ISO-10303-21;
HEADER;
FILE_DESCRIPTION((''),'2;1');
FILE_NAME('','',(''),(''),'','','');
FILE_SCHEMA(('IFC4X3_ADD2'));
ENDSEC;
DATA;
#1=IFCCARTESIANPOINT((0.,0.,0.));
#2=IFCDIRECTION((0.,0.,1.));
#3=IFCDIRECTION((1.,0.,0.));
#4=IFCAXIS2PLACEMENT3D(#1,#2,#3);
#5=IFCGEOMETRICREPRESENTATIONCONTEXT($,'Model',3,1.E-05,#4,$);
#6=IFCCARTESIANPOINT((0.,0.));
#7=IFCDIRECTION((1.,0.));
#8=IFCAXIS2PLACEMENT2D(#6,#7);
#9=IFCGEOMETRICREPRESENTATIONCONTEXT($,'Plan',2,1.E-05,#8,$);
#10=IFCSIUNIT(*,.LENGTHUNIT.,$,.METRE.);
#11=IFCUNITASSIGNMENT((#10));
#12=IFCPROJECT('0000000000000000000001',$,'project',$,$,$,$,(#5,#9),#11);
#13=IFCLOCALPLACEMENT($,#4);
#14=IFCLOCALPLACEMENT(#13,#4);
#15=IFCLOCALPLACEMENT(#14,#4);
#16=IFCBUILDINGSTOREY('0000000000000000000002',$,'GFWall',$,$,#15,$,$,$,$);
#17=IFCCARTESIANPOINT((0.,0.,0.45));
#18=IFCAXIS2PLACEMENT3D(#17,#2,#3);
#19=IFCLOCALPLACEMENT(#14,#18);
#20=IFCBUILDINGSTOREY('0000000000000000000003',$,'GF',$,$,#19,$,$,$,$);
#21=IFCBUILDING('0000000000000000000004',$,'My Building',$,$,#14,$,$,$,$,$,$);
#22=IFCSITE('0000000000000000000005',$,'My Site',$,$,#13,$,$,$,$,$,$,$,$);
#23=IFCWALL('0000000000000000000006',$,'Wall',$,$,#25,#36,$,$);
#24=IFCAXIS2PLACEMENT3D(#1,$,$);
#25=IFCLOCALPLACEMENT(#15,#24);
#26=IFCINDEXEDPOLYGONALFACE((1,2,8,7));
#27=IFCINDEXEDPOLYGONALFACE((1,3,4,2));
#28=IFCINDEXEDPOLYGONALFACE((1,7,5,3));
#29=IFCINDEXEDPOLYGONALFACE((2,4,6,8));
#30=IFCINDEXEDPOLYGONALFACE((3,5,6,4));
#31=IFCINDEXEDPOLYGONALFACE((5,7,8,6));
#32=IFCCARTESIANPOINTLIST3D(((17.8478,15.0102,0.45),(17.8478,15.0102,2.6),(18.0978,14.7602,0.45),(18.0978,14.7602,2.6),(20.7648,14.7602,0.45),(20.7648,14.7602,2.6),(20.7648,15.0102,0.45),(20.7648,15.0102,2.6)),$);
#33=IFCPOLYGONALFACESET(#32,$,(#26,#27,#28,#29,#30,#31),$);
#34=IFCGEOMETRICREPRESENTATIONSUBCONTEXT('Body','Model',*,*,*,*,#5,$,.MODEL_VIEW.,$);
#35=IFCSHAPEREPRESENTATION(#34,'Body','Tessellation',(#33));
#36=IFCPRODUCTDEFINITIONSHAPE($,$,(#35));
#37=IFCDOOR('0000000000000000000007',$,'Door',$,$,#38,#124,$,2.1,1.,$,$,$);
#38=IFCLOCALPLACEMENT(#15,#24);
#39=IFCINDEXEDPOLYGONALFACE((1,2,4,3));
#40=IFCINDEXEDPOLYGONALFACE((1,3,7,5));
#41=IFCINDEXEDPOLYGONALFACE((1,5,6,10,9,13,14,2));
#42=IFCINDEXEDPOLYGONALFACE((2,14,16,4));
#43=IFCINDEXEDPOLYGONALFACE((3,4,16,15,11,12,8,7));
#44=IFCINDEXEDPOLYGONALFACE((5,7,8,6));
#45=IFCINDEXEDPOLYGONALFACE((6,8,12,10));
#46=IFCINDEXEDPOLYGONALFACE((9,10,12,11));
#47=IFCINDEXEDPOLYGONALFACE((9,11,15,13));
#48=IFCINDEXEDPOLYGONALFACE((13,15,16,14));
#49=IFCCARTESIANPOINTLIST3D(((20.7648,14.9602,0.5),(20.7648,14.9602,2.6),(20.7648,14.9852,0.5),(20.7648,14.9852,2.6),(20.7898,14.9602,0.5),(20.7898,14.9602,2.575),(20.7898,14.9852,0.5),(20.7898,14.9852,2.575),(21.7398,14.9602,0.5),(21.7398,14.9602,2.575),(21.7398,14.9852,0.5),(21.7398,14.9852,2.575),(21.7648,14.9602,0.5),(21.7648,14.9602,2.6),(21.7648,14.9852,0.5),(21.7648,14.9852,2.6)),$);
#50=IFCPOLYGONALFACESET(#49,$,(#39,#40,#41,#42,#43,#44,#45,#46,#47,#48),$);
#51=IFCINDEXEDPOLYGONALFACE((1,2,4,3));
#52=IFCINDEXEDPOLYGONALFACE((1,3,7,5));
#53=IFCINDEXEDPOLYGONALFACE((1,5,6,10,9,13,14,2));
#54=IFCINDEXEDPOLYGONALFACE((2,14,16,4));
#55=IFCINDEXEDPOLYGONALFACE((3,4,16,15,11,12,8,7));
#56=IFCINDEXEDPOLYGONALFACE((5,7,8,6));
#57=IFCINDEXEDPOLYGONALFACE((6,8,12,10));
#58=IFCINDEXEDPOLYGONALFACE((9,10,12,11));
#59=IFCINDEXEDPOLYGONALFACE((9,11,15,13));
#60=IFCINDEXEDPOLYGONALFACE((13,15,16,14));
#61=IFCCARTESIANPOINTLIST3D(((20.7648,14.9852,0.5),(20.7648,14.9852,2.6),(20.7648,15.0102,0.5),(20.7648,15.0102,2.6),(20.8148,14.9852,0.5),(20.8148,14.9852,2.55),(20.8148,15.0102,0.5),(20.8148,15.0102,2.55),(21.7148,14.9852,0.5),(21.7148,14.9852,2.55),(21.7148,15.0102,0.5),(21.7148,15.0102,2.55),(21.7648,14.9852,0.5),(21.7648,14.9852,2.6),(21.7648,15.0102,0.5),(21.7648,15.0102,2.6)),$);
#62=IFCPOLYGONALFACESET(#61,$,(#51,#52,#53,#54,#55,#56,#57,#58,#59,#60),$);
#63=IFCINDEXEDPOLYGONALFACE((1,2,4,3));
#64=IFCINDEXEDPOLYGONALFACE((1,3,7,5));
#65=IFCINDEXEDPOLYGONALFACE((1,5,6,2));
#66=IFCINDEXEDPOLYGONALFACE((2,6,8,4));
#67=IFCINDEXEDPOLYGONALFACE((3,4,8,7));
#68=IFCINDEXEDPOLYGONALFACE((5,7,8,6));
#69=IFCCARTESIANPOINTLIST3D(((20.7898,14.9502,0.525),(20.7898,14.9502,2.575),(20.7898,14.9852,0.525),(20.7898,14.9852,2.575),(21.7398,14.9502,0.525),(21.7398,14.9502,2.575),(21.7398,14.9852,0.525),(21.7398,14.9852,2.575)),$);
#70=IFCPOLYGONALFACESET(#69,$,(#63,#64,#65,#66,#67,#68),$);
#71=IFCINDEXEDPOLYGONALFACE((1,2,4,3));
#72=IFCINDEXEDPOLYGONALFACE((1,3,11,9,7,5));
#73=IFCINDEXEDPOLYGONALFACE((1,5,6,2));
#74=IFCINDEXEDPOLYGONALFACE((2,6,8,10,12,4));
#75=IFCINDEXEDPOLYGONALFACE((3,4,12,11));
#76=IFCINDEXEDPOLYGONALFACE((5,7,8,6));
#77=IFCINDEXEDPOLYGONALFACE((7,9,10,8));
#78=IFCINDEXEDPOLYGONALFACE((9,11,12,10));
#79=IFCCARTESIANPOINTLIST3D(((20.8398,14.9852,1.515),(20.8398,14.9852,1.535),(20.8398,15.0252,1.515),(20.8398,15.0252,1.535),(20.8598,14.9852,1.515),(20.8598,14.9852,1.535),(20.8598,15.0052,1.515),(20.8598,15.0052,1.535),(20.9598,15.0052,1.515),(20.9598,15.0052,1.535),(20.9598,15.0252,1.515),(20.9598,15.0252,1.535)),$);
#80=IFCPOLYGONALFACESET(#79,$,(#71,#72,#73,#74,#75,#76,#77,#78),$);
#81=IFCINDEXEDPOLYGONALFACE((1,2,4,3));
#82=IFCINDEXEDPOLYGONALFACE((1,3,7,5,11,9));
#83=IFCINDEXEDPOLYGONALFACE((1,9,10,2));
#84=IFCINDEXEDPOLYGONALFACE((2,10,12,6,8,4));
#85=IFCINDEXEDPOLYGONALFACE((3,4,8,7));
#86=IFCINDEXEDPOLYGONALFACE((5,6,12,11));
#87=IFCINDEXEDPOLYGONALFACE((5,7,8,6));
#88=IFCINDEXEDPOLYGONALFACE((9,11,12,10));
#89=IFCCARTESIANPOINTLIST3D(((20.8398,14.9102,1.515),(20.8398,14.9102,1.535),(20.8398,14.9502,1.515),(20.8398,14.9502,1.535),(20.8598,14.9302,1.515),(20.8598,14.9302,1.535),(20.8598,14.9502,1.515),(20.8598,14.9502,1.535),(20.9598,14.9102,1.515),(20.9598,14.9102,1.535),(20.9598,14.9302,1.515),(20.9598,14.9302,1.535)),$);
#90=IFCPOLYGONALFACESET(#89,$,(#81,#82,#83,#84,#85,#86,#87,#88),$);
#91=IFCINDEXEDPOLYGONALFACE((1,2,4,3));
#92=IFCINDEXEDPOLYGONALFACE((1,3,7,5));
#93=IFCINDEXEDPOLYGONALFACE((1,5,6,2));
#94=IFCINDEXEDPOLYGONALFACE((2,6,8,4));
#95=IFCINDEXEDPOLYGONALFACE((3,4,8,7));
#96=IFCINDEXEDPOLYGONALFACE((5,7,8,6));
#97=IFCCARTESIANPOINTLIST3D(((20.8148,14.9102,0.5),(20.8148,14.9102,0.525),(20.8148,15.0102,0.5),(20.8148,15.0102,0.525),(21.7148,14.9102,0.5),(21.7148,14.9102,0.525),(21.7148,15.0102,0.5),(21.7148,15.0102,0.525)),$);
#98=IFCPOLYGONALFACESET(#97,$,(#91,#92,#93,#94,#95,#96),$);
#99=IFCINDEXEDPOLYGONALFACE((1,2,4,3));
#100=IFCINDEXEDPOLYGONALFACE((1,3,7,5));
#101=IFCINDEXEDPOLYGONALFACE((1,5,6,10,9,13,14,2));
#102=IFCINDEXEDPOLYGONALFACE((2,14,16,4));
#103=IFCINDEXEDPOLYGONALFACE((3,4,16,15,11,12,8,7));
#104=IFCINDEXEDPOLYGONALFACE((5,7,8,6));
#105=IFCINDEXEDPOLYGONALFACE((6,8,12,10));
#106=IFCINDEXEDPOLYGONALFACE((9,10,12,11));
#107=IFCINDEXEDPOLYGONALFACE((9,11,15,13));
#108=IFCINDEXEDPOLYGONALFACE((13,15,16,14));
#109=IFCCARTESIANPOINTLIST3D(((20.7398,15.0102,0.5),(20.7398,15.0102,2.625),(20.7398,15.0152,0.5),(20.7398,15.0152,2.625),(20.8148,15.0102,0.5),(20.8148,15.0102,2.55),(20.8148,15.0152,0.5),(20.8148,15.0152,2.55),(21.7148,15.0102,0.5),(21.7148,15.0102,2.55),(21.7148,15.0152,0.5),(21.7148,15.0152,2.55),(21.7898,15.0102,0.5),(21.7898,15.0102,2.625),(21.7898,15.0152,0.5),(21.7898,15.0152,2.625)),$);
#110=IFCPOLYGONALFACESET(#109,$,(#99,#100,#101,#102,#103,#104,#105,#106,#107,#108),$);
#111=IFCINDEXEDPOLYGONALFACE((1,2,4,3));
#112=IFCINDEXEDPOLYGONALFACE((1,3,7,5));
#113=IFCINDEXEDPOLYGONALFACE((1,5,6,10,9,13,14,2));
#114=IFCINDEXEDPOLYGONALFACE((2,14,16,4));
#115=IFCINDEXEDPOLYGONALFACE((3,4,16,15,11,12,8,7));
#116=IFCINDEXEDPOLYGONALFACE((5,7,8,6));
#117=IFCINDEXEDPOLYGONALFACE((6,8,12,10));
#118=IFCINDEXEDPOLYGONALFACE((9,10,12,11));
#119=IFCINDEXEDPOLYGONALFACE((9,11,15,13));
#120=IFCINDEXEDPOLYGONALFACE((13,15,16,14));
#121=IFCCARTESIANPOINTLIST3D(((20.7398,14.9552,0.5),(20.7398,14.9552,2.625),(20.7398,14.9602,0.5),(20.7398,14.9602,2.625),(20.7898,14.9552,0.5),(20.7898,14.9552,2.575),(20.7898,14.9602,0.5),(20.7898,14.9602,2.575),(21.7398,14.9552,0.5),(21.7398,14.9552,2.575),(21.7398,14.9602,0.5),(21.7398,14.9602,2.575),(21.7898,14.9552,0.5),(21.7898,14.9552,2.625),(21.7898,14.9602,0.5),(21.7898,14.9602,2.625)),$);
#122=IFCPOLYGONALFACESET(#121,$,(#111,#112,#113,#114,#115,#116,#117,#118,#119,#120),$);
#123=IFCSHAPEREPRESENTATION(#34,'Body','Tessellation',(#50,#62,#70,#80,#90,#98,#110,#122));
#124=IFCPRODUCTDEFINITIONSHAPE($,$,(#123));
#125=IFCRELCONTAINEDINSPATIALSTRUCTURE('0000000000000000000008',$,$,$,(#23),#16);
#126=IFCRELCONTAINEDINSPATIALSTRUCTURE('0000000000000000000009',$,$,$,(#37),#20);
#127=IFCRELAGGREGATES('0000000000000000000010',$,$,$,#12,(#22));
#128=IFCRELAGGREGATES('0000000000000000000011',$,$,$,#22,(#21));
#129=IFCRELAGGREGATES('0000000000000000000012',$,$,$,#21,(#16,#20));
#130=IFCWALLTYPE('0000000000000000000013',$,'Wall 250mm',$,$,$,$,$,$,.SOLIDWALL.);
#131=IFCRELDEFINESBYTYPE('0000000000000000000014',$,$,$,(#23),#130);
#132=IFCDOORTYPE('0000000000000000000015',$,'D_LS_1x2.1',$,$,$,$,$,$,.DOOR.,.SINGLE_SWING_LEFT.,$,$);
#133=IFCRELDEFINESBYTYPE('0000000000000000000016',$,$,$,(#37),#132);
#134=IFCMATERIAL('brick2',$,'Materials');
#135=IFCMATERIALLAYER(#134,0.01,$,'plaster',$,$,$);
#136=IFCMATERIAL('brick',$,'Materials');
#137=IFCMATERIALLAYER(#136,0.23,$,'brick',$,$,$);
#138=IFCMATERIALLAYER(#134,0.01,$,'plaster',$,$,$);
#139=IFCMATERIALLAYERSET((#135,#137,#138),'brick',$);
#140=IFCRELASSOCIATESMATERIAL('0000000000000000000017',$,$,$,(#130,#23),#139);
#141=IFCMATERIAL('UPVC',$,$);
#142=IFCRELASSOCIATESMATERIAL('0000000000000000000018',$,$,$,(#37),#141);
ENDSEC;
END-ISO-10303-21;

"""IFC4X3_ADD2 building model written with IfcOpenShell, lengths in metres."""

from ifc_helpers import new_model, entity, si_unit, frame, origin_with_axes, origin_2d_with_axis, place, context, subcontext, project, spatial, line, indexed_curve, outline, extrude, shape, source, transform, mapped, material, layer, layer_set, layer_usage, type_object, type_shapes, element, fill, save


model = new_model("IFC4X3_ADD2")

# Units and contexts
model_context = context("Model", 3, precision=1e-05, world=origin_with_axes())
plan_context = context("Plan", 2, precision=1e-05, world=origin_2d_with_axis())
body_context_1 = subcontext(model_context, "Body", "Model", "MODEL_VIEW")
body_context_2 = subcontext(plan_context, "Body", "Plan", "PLAN_VIEW")
ifc_project = project(units=[si_unit("LENGTHUNIT", "METRE")], contexts=[model_context, plan_context])

# Site, building, storey
site_placement = place(None, origin_with_axes())
site = spatial("IfcSite", under=ifc_project, at=site_placement, Name="My Site")
building_placement = place(site_placement, origin_with_axes())
building = spatial("IfcBuilding", under=site, at=building_placement, Name="My Building")
storey_1_placement = place(building_placement, origin_with_axes())
storey_1 = spatial("IfcBuildingStorey", under=building, at=storey_1_placement, Name="GFWall")

# Shared definitions
ifc_material_1 = material(Name="brick2", Category="Materials")
ifc_layer_1 = layer(ifc_material_1, 0.01, Name="plaster")
ifc_material_2 = material(Name="brick", Category="Materials")
ifc_layer_2 = layer(ifc_material_2, 0.23, Name="brick")
ifc_layer_3 = layer(ifc_material_1, 0.01, Name="plaster")
ifc_layer_set_1 = layer_set([ifc_layer_1, ifc_layer_2, ifc_layer_3], Name="brick")
wall_type_1 = type_object("IfcWallType", Name="Wall 250mm", PredefinedType="SOLIDWALL", material=ifc_layer_set_1)

# Shared definitions
storey_2_placement = place(building_placement, frame((0.0, 0.0, 0.45), z_axis=(0.0, 0.0, 1.0), x_axis=(1.0, 0.0, 0.0)))
storey_2 = spatial("IfcBuildingStorey", under=building, at=storey_2_placement, Name="GF")

# Wall, opening, door
ifc_layer_usage_1 = layer_usage(ifc_layer_set_1, "AXIS2", "POSITIVE", 0.0)
wall_1_placement = place(storey_1_placement, frame((21.7648, 15.0102, 0.45), z_axis=(0.0, 0.0, 1.0), x_axis=(-1.0, 0.0, 0.0)))
wall_1 = element("IfcWall", 1, at=wall_1_placement, inside=storey_1, type_object=wall_type_1, material=ifc_layer_usage_1, Name="Wall", context=body_context_1, shape_type="SweptSolid", body=[
    extrude(outline(indexed_curve([(0.0, 0.0), (0.0, 0.25), (3.667, 0.25), (3.917, 0.0)], segments=[line(1, 2, 3, 4, 1)])), origin_with_axes(), (0.0, 0.0, 1.0), 2.15),
])
shared_shape_1 = source(origin_with_axes(), body_context_1, "Body", "SweptSolid", [
    extrude(outline(indexed_curve([(0.0, 2.1), (1.0, 2.1), (1.0, -0.05), (0.0, -0.05), (0.0, 2.1)])), frame((0.0, -0.6, 0.0), z_axis=(0.0, -1.0, 0.0), x_axis=(1.0, 0.0, 0.0)), (0.0, 0.0, -1.0), 1.2),
])
opening_1_placement = place(wall_1_placement, frame((0.0, 0.0, 0.05), z_axis=(0.0, 0.0, 1.0), x_axis=(1.0, 0.0, 0.0)))
opening_1 = element("IfcOpeningElement", 2, at=opening_1_placement, cuts=wall_1, PredefinedType="OPENING", context=body_context_1, shape_type="MappedRepresentation", body=[
    mapped(shared_shape_1, transform((0.0, 0.0, 0.0), x_axis=(1.0, 0.0, 0.0), y_axis=(0.0, 1.0, 0.0), z_axis=(0.0, 0.0, 1.0), scale=1.0)),
])
ifc_material_3 = material(Name="UPVC")
door_type_1 = type_object("IfcDoorType", Name="D_LS_1x2.1", OperationType="SINGLE_SWING_LEFT", PredefinedType="DOOR")
shared_shape_2 = source(origin_with_axes(), body_context_1, "Body", "SweptSolid", [
    extrude(outline(indexed_curve([(0.0, 0.0), (0.0, 2.1), (1.0, 2.1), (1.0, 0.0), (0.975, 0.0), (0.975, 2.075), (0.025, 2.075), (0.025, 0.0)], segments=[line(1, 2, 3, 4, 5, 6, 7, 8, 1)])), frame((0.0, 0.025, 0.0), z_axis=(0.0, -1.0, 0.0), x_axis=(1.0, 0.0, 0.0)), (0.0, 0.0, -1.0), 0.025),
    extrude(outline(indexed_curve([(0.0, 0.0), (0.0, 2.1), (1.0, 2.1), (1.0, 0.0), (0.95, 0.0), (0.95, 2.05), (0.05, 2.05), (0.05, 0.0)], segments=[line(1, 2, 3, 4, 5, 6, 7, 8, 1)])), frame((0.0, 0.0, 0.0), z_axis=(0.0, -1.0, 0.0), x_axis=(1.0, 0.0, 0.0)), (0.0, 0.0, -1.0), 0.025),
    extrude(outline(indexed_curve([(0.0, 0.0), (0.95, 0.0), (0.95, 0.035), (0.0, 0.035)], segments=[line(1, 2, 3, 4, 1)])), frame((0.025, 0.025, 0.025), z_axis=(0.0, 0.0, 1.0), x_axis=(1.0, 0.0, 0.0)), (0.0, 0.0, 1.0), 2.05),
    extrude(outline(indexed_curve([(0.0, 0.0), (0.0, -0.04), (-0.12, -0.04), (-0.12, -0.02), (-0.02, -0.02), (-0.02, 0.0)], segments=[line(1, 2, 3, 4, 5, 6, 1)])), frame((0.925, 0.025, 1.015), z_axis=(0.0, 0.0, 1.0), x_axis=(1.0, 0.0, 0.0)), (0.0, 0.0, 1.0), 0.02),
    extrude(outline(indexed_curve([(0.0, 0.0), (0.0, 0.04), (-0.12, 0.04), (-0.12, 0.02), (-0.02, 0.02), (-0.02, 0.0)], segments=[line(1, 2, 3, 4, 5, 6, 1)])), frame((0.925, 0.06, 1.015), z_axis=(0.0, 0.0, 1.0), x_axis=(1.0, 0.0, 0.0)), (0.0, 0.0, 1.0), 0.02),
    extrude(outline(indexed_curve([(0.0, 0.0), (0.9, 0.0), (0.9, 0.1), (0.0, 0.1)], segments=[line(1, 2, 3, 4, 1)])), frame((0.05, 0.0, 0.0), z_axis=(0.0, 0.0, 1.0), x_axis=(1.0, 0.0, 0.0)), (0.0, 0.0, 1.0), 0.025),
    extrude(outline(indexed_curve([(0.0, 0.0), (0.0, 2.125), (1.05, 2.125), (1.05, 0.0), (0.975, 0.0), (0.975, 2.05), (0.075, 2.05), (0.075, 0.0)], segments=[line(1, 2, 3, 4, 5, 6, 7, 8, 1)])), frame((-0.025, -0.005, 0.0), z_axis=(0.0, -1.0, 0.0), x_axis=(1.0, 0.0, 0.0)), (0.0, 0.0, -1.0), 0.005),
    extrude(outline(indexed_curve([(0.0, 0.0), (0.0, 2.125), (1.05, 2.125), (1.05, 0.0), (1.0, 0.0), (1.0, 2.075), (0.05, 2.075), (0.05, 0.0)], segments=[line(1, 2, 3, 4, 5, 6, 7, 8, 1)])), frame((-0.025, 0.05, 0.0), z_axis=(0.0, -1.0, 0.0), x_axis=(1.0, 0.0, 0.0)), (0.0, 0.0, -1.0), 0.005),
])
shared_shape_3 = source(origin_with_axes(), body_context_2, "Body", "Curve2D", [
    entity("IfcIndexedPolyCurve", entity("IfcCartesianPointList2D", [[0.0, 0.0], [0.0, 0.05], [0.025, 0.05], [0.025, 0.025], [0.05, 0.025], [0.05, 0.0]]), [entity("IfcLineIndex", [1, 2, 3, 4, 5, 6, 1])]),
    entity("IfcIndexedPolyCurve", entity("IfcCartesianPointList2D", [[1.0, 0.0], [1.0, 0.05], [0.975, 0.05], [0.975, 0.025], [0.95, 0.025], [0.95, 0.0]]), [entity("IfcLineIndex", [1, 2, 3, 4, 5, 6, 1])]),
    entity("IfcTrimmedCurve", entity("IfcEllipse", entity("IfcAxis2Placement2D", entity("IfcCartesianPoint", [0.06, 0.05]), entity("IfcDirection", [1.0, 0.0])), 0.915, 0.95), [entity("IfcCartesianPoint", [0.975, 0.05])], [entity("IfcCartesianPoint", [0.06, 1.0])], True, "CARTESIAN"),
    entity("IfcIndexedPolyCurve", entity("IfcCartesianPointList2D", [[0.025, 0.05], [0.06, 0.05], [0.06, 1.0], [0.025, 1.0]]), [entity("IfcLineIndex", [1, 2, 3, 4, 1])]),
])
type_shapes(door_type_1, [shared_shape_2, shared_shape_3])
door_1_placement = place(opening_1_placement, frame((0.0, 0.0, 0.0), z_axis=(0.0, 0.0, 1.0), x_axis=(1.0, 0.0, 0.0)))
door_1 = element("IfcDoor", 3, at=door_1_placement, inside=storey_2, type_object=door_type_1, material=ifc_material_3, Name="Door", OverallHeight=2.1, OverallWidth=1.0, shapes=[
    shape(body_context_1, "Body", "MappedRepresentation", [mapped(shared_shape_2, transform((0.0, 0.0, 0.0), x_axis=(1.0, 0.0, 0.0), y_axis=(0.0, 1.0, 0.0), z_axis=(0.0, 0.0, 1.0), scale=1.0))]),
    shape(body_context_2, "Body", "MappedRepresentation", [mapped(shared_shape_3, transform((0.0, 0.0, 0.0), x_axis=(1.0, 0.0, 0.0), y_axis=(0.0, 1.0, 0.0), z_axis=(0.0, 0.0, 1.0), scale=1.0))]),
])
fill(opening_1, door_1)

save(model, "model.ifc")
